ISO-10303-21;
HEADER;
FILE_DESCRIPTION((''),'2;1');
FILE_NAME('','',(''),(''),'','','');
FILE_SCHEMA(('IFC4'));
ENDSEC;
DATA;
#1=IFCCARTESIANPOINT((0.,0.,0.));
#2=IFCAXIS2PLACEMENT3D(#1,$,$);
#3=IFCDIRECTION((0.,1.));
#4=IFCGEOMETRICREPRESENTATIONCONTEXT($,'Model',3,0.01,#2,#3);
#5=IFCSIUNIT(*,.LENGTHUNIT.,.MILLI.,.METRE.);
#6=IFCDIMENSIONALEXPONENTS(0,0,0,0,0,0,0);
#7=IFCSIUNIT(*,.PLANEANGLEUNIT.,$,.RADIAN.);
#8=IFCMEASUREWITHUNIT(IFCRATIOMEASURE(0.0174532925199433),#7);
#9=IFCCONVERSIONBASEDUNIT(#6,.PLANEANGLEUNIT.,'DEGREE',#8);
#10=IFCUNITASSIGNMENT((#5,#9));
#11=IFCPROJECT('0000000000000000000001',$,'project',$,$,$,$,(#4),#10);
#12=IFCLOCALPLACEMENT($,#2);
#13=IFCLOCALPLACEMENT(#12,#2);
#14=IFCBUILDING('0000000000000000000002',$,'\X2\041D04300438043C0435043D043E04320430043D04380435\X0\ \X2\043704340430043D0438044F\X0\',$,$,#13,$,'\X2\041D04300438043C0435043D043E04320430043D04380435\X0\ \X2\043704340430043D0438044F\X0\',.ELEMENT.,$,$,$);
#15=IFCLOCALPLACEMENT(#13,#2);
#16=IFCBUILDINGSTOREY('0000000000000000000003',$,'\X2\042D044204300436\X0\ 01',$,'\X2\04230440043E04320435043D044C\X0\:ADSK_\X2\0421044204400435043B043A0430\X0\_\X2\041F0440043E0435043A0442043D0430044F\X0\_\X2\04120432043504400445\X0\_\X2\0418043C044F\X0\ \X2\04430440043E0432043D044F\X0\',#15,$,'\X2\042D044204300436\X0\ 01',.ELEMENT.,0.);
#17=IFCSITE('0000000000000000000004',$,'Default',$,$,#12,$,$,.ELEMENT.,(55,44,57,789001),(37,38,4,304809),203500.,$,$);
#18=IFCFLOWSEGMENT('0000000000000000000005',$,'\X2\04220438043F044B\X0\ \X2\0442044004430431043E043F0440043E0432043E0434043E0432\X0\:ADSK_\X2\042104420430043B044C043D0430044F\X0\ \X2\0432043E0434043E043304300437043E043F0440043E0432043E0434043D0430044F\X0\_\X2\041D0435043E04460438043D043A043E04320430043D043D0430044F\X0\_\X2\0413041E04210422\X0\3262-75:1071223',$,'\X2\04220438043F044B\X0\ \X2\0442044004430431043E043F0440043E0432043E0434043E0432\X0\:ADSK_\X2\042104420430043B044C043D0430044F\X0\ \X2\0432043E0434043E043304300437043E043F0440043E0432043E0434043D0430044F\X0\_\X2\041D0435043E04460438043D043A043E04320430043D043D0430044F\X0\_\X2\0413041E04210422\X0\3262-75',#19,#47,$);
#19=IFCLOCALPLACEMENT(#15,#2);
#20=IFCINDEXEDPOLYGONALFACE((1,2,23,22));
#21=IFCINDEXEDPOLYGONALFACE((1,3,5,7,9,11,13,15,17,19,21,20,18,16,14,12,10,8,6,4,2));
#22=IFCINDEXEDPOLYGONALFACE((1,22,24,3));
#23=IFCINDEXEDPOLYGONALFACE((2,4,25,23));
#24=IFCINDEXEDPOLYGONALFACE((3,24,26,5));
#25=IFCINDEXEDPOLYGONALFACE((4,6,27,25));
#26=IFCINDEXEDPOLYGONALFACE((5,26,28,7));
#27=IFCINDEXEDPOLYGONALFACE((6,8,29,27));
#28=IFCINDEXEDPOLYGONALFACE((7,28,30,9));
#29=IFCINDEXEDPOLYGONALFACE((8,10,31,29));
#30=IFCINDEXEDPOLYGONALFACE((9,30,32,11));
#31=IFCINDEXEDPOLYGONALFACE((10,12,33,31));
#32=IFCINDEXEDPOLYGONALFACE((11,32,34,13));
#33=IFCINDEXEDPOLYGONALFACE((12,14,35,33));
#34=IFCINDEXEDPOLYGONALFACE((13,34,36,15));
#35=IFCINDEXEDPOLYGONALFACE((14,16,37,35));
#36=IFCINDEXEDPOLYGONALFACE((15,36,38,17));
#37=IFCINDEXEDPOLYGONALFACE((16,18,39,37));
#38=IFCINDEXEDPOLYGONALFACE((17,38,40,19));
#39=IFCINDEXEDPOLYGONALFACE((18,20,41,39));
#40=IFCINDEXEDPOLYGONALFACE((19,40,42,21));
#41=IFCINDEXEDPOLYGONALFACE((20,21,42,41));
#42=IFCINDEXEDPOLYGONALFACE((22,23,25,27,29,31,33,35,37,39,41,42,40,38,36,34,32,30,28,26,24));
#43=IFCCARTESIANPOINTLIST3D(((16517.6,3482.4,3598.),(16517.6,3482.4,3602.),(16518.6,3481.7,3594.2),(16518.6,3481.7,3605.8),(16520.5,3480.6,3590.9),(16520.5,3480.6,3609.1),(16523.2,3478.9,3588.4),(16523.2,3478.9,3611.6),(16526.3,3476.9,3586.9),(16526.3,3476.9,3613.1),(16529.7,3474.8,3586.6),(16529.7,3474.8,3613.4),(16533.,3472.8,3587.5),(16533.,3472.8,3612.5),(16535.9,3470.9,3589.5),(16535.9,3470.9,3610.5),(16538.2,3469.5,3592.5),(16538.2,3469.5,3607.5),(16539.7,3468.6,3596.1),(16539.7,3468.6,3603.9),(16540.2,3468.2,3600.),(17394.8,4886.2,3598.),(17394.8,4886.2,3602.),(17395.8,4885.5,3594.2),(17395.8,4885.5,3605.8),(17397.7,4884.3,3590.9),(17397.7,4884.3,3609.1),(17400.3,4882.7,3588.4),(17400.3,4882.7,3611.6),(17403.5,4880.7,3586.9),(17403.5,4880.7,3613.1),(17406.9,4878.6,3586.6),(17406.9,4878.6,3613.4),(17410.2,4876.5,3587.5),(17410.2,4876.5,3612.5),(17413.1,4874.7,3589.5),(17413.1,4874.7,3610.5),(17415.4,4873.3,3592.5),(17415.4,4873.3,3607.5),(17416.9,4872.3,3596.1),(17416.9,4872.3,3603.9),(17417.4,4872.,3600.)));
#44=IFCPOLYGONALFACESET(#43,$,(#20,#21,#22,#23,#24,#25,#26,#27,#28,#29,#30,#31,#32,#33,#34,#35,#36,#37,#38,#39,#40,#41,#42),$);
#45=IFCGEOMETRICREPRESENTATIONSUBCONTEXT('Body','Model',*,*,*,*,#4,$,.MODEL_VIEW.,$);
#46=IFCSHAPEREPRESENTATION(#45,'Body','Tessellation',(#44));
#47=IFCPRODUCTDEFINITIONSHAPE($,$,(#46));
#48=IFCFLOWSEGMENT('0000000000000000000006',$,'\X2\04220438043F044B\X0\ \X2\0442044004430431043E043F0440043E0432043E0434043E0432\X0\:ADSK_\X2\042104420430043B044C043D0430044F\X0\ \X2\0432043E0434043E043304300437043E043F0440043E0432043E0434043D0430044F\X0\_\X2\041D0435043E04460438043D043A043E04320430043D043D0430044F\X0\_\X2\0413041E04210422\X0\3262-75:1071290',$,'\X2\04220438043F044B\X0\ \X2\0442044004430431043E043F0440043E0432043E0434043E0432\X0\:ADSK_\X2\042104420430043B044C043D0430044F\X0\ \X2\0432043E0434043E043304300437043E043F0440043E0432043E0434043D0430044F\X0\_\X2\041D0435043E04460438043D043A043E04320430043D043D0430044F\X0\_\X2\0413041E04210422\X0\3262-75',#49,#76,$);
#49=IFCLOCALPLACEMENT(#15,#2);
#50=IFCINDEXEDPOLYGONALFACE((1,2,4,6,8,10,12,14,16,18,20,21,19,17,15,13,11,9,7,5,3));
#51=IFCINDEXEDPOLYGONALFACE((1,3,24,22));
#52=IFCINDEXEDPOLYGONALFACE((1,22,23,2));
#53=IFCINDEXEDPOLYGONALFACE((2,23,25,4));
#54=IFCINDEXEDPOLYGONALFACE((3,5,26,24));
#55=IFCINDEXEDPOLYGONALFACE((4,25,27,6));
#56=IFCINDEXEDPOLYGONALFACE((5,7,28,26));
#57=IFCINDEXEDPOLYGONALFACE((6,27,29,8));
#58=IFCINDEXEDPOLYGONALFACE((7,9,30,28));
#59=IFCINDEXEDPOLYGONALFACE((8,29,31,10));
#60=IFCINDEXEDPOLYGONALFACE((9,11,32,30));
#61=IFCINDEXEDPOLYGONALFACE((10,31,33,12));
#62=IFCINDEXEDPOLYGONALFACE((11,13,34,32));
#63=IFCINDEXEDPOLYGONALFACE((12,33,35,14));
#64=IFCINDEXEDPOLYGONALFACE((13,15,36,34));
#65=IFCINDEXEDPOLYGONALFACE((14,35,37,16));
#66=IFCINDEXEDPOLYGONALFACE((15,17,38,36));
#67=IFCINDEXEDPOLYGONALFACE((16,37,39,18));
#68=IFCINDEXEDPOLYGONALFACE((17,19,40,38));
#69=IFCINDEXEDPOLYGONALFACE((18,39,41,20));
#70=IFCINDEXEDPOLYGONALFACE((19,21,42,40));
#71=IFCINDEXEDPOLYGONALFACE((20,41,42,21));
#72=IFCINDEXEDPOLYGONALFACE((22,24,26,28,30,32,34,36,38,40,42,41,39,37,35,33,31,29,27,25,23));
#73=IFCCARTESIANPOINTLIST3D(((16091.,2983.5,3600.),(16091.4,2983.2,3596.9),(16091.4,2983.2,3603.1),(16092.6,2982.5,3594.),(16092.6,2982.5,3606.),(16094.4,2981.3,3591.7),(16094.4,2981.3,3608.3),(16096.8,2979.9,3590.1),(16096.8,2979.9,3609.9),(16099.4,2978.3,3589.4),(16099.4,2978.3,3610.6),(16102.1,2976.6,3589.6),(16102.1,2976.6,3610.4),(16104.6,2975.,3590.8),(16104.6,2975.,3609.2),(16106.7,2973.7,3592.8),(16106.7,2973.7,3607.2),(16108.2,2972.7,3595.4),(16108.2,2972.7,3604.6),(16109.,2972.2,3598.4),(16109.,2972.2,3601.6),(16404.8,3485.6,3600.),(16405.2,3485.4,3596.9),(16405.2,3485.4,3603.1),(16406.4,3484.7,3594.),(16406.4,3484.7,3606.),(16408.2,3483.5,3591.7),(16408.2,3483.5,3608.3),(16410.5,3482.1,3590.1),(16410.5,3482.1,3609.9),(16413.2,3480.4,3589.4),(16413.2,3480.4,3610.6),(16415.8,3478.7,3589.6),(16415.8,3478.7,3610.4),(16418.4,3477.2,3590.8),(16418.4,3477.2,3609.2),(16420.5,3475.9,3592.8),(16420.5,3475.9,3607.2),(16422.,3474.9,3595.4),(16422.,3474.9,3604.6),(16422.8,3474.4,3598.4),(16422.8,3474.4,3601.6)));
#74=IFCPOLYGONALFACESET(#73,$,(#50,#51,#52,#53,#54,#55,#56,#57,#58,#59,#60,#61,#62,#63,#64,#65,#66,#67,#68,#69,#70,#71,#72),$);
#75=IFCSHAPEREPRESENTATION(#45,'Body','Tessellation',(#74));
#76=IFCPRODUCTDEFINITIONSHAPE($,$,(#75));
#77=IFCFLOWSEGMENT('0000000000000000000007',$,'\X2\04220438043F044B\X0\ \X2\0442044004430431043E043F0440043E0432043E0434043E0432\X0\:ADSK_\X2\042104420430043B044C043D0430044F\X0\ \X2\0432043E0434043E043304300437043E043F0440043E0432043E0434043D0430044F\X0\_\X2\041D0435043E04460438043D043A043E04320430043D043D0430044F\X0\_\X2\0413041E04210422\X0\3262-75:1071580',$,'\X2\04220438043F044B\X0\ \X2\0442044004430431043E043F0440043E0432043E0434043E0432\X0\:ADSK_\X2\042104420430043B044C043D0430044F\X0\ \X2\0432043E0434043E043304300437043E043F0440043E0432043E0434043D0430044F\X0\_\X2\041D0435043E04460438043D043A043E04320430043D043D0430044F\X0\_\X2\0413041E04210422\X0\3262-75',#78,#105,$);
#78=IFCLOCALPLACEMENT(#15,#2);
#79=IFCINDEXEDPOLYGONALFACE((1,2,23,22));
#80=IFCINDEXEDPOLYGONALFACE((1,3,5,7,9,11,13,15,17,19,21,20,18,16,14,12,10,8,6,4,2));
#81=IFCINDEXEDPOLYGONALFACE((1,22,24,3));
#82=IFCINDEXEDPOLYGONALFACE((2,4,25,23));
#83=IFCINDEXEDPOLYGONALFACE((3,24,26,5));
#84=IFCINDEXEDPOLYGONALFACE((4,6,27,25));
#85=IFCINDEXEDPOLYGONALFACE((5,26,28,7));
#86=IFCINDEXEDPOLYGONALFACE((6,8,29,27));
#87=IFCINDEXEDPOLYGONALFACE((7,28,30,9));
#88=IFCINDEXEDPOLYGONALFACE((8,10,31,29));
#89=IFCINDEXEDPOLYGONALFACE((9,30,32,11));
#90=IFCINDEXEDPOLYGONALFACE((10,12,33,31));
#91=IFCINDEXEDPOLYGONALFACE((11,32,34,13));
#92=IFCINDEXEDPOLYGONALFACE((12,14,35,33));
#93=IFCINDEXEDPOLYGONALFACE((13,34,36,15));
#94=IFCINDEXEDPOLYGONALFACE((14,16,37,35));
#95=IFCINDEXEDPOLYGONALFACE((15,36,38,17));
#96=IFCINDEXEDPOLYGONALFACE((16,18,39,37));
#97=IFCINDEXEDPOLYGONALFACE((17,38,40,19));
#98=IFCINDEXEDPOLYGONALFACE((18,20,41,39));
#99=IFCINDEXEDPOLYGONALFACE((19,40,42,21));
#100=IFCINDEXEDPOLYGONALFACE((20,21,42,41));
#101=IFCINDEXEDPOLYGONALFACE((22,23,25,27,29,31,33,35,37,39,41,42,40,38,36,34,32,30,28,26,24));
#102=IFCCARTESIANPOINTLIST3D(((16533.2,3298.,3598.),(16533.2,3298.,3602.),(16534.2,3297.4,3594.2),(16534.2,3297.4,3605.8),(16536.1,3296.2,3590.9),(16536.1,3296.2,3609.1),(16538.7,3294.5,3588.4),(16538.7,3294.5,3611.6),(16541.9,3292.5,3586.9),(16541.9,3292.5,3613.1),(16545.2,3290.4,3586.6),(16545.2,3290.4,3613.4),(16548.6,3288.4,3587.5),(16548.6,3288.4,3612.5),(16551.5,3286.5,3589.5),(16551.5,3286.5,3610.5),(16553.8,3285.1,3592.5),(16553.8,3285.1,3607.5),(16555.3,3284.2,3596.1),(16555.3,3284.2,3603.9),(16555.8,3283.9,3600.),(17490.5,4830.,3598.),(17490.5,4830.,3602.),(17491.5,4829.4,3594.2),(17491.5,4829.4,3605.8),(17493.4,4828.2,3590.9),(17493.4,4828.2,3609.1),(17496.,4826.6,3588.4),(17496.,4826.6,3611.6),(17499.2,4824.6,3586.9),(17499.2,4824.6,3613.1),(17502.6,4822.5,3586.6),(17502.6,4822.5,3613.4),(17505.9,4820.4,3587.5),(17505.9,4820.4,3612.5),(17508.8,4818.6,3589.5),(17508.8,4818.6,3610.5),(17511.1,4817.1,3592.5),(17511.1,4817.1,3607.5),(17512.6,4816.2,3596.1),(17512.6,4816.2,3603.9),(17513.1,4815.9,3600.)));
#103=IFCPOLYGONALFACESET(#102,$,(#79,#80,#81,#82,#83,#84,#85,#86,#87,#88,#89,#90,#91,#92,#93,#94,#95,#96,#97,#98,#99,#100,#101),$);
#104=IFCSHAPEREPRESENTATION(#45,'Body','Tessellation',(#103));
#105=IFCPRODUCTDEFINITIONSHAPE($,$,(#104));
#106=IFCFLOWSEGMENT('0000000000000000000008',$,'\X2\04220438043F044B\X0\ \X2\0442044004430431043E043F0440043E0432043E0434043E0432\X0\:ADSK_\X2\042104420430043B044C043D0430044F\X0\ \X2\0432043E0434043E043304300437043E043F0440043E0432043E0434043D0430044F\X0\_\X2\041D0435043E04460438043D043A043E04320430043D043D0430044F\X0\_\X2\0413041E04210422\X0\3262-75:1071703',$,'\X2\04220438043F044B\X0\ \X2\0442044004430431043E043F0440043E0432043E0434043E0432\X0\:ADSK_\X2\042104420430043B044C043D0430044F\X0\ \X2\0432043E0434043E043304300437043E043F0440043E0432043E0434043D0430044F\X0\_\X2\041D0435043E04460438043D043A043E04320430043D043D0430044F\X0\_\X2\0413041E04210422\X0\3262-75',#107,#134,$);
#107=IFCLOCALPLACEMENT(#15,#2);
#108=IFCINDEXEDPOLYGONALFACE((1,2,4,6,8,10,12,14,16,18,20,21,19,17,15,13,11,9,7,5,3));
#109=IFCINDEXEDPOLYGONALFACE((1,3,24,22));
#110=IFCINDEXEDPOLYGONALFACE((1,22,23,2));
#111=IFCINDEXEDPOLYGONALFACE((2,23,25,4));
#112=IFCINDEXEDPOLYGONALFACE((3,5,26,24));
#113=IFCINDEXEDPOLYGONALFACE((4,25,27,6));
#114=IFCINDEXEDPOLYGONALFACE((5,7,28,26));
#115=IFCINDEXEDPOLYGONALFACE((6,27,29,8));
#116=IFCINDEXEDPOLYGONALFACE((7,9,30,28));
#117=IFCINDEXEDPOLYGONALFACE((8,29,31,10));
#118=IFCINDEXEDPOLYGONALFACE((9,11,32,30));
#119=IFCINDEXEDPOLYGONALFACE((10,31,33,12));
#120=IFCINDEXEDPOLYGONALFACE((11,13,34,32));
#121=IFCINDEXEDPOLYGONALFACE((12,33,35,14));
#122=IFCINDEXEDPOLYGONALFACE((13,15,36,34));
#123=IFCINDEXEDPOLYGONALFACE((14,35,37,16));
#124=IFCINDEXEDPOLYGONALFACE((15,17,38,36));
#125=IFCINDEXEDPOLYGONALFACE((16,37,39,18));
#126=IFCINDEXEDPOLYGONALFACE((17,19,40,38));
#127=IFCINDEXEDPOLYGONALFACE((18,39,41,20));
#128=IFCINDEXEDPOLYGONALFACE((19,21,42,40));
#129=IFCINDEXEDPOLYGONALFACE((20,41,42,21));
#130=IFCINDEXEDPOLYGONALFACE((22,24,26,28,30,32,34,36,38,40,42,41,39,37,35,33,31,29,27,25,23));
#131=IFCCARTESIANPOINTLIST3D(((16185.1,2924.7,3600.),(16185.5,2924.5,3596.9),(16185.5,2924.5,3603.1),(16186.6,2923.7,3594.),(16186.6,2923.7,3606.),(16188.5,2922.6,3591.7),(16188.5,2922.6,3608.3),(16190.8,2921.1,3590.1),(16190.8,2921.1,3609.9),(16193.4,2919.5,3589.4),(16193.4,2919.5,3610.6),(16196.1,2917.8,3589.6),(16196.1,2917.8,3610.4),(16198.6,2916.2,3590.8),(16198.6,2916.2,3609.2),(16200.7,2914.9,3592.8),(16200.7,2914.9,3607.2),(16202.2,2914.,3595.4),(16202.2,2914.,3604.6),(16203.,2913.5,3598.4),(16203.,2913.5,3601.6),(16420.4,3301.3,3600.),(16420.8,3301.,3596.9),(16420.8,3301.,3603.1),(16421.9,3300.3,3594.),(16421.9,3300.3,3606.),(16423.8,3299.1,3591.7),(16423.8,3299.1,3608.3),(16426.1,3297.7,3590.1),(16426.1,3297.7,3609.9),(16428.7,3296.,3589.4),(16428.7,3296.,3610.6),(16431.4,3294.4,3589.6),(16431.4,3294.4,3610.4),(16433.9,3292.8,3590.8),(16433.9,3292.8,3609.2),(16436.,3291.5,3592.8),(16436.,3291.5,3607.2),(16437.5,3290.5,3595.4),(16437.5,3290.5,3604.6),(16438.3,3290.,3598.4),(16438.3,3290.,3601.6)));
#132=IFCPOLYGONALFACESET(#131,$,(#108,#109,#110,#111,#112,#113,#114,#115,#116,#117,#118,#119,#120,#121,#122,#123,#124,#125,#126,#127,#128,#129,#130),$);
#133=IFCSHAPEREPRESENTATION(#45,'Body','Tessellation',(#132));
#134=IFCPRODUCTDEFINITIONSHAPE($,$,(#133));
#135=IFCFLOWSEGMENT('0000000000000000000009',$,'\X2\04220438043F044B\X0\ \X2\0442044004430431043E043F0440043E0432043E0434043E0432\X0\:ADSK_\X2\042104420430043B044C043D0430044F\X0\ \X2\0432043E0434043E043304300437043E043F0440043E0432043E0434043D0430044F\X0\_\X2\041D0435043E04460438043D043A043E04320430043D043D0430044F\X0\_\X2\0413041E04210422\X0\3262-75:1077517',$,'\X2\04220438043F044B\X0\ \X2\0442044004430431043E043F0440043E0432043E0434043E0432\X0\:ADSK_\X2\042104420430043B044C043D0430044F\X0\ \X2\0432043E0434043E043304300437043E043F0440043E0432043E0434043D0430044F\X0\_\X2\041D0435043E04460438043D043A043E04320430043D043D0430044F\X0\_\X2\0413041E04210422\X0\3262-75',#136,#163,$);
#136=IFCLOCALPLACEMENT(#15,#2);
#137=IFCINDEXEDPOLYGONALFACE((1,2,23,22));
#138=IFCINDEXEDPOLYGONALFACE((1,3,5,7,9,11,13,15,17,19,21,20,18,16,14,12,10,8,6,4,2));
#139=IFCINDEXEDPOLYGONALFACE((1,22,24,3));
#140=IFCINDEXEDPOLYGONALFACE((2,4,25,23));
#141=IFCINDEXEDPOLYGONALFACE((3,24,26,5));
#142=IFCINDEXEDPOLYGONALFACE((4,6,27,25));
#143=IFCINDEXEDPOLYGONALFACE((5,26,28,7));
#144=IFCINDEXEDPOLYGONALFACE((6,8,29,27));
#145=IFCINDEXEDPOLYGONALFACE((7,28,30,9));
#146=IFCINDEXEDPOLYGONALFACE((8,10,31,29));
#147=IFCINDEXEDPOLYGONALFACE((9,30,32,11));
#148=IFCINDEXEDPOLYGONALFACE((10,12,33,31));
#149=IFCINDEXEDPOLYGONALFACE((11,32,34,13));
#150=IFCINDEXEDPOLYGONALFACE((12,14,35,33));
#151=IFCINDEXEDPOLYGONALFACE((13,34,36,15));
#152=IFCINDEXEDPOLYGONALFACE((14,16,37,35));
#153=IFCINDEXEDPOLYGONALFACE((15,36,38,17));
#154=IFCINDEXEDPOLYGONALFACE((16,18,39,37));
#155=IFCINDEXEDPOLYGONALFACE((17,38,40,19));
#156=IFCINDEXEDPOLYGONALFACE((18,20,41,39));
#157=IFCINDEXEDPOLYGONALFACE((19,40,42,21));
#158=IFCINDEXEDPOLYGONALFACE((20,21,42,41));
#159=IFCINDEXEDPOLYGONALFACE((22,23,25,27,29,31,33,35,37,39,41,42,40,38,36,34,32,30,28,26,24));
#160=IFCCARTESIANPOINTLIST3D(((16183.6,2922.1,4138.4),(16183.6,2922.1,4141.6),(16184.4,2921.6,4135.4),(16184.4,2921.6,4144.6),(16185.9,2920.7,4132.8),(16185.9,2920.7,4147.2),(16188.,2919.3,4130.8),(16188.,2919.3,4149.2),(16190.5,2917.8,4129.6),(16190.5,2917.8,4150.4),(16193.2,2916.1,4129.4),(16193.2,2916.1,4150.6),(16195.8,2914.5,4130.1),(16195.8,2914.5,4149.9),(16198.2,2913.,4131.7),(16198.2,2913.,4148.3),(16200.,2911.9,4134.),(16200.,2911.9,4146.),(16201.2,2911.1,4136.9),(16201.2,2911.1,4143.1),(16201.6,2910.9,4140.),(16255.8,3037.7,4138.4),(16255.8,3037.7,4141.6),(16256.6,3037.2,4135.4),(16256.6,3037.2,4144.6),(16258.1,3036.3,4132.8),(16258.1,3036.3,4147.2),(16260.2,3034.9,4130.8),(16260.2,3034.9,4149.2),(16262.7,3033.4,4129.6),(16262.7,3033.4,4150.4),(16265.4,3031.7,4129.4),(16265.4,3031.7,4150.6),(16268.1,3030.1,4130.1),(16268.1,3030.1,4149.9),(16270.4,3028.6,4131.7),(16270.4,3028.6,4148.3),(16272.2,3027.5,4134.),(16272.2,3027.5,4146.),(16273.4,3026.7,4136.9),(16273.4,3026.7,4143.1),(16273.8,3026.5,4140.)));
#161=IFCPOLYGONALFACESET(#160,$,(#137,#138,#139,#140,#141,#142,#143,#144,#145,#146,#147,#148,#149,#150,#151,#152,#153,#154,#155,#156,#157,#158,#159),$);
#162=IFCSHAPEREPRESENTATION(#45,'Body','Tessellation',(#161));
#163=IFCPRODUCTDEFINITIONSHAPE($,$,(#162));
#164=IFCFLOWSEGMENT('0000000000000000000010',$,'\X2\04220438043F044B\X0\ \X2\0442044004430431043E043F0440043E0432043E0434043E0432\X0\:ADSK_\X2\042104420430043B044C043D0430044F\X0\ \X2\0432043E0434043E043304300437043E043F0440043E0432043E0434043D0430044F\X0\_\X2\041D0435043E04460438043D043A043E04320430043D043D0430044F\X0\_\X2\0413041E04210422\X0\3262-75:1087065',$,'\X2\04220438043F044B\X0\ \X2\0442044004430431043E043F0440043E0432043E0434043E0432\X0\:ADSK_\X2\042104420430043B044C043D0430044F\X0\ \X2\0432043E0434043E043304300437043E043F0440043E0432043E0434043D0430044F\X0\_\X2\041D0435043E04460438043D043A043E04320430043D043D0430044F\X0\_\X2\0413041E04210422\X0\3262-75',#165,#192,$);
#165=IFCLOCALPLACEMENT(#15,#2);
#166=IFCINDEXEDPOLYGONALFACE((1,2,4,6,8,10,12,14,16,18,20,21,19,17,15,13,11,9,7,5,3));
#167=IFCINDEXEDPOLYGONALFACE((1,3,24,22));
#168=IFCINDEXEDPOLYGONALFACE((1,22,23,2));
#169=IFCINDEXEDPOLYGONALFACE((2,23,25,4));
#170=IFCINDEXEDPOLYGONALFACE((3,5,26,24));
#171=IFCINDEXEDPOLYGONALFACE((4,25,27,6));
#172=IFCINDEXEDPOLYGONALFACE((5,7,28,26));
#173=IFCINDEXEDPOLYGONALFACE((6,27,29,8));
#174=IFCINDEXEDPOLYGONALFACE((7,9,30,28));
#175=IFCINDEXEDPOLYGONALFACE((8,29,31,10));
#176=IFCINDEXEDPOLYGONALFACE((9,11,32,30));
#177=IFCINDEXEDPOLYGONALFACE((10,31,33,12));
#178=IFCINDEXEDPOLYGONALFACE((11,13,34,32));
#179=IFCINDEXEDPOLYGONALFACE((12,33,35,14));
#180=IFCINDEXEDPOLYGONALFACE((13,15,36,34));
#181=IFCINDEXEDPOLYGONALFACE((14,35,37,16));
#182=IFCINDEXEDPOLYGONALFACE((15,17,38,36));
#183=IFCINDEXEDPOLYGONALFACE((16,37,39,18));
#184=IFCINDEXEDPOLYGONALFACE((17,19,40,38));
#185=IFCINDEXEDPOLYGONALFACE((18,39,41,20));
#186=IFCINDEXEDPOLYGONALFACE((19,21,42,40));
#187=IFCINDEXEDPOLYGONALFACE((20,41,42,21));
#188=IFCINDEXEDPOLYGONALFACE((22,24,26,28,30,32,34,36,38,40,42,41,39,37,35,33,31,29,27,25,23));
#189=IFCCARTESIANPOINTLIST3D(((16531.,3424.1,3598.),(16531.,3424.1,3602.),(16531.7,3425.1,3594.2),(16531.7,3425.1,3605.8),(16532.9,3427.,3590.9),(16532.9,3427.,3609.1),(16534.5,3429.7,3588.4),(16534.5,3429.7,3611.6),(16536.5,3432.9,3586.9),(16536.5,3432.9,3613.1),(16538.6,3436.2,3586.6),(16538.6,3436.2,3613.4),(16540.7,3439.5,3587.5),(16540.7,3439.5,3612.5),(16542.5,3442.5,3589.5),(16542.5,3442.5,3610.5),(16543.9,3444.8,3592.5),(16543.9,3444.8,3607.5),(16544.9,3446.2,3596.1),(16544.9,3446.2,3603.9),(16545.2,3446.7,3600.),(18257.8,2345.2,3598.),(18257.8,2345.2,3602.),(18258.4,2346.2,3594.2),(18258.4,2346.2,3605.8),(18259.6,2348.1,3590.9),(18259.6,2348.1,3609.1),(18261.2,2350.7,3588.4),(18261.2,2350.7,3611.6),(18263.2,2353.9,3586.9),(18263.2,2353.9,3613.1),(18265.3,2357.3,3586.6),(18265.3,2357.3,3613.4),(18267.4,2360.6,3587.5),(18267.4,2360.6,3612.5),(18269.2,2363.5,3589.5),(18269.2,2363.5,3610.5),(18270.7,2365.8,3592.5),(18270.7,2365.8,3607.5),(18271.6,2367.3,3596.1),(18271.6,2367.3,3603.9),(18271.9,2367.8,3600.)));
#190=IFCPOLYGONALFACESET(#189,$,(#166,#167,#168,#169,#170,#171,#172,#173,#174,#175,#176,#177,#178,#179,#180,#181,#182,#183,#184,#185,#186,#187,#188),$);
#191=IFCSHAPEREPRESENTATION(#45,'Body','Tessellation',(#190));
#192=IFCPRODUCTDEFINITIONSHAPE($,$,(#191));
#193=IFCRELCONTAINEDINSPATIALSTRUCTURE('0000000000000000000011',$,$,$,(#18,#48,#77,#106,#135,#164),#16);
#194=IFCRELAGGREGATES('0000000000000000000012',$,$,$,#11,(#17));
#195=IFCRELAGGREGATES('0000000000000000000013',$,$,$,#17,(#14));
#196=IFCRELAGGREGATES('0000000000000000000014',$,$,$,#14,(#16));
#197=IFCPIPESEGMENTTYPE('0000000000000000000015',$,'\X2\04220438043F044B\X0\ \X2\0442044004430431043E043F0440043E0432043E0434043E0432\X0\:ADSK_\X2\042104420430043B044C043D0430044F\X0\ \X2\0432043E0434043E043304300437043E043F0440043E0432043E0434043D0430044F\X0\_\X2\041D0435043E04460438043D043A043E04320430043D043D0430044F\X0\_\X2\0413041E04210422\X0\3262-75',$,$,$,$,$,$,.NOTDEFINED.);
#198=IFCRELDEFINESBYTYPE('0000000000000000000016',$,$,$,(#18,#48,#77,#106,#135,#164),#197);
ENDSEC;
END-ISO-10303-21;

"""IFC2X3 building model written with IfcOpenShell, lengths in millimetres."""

from ifc_helpers import new_model, entity, si_unit, converted_unit, direction, frame, origin, origin_2d_with_axis, place, context, subcontext, project, spatial, circle, extrude, type_object, element, save


model = new_model("IFC2X3")

# Units and contexts
model_context = context("Model", 3, precision=0.01, world=origin(), true_north=direction((0.0, 1.0)))
body_context = subcontext(model_context, "Body", "Model", "MODEL_VIEW")
ifc_project = project(units=[si_unit("LENGTHUNIT", "METRE", prefix="MILLI"), converted_unit("PLANEANGLEUNIT", "DEGREE", entity("IfcRatioMeasure", 0.0174532925199433), si_unit("PLANEANGLEUNIT", "RADIAN"), dimensions=[0, 0, 0, 0, 0, 0, 0])], contexts=[model_context])

# Site, building, storey
site_placement = place(None, origin())
site = spatial("IfcSite", under=ifc_project, at=site_placement, Name="Default", CompositionType="ELEMENT", RefLatitude=(55, 44, 57, 789001), RefLongitude=(37, 38, 4, 304809), RefElevation=203500.0)
building_placement = place(site_placement, origin())
building = spatial("IfcBuilding", under=site, at=building_placement, Name="Наименование здания", LongName="Наименование здания", CompositionType="ELEMENT")
storey_placement = place(building_placement, origin())
storey = spatial("IfcBuildingStorey", under=building, at=storey_placement, Name="Этаж 01", ObjectType="Уровень:ADSK_Стрелка_Проектная_Вверх_Имя уровня", LongName="Этаж 01", CompositionType="ELEMENT", Elevation=0.0)

# Flow segments
pipe_segment_type = type_object("IfcPipeSegmentType", Name="Типы трубопроводов:ADSK_Стальная водогазопроводная_Неоцинкованная_ГОСТ3262-75", PredefinedType="NOTDEFINED")
flow_segment_1_placement = place(storey_placement, frame((16515.9, 3466.7, 3585.0)))
element("IfcFlowSegment", 1, at=flow_segment_1_placement, inside=storey, type_object=pipe_segment_type, Name="Типы трубопроводов:ADSK_Стальная водогазопроводная_Неоцинкованная_ГОСТ3262-75:1071223", ObjectType="Типы трубопроводов:ADSK_Стальная водогазопроводная_Неоцинкованная_ГОСТ3262-75", context=body_context, shape_type="SweptSolid", body=[
    extrude(circle(Radius=13.4, at=origin_2d_with_axis()), frame((13.0, 8.7, 15.0), z_axis=(0.529912, 0.848053, 0.0), x_axis=(0.848053, -0.529912, 0.0)), (0.0, 0.0, 1.0), 1655.3),
])
flow_segment_2_placement = place(storey_placement, frame((16089.4, 2970.6, 3587.8)))
element("IfcFlowSegment", 2, at=flow_segment_2_placement, inside=storey, type_object=pipe_segment_type, Name="Типы трубопроводов:ADSK_Стальная водогазопроводная_Неоцинкованная_ГОСТ3262-75:1071290", ObjectType="Типы трубопроводов:ADSK_Стальная водогазопроводная_Неоцинкованная_ГОСТ3262-75", context=body_context, shape_type="SweptSolid", body=[
    extrude(circle(Radius=10.7, at=origin_2d_with_axis()), frame((10.6, 7.2, 12.2), z_axis=(0.529911, 0.848053, 0.0), x_axis=(-0.848053, 0.529911, 0.0)), (0.0, 0.0, 1.0), 592.1),
])
flow_segment_3_placement = place(storey_placement, frame((16531.4, 3282.3, 3585.0)))
element("IfcFlowSegment", 3, at=flow_segment_3_placement, inside=storey, type_object=pipe_segment_type, Name="Типы трубопроводов:ADSK_Стальная водогазопроводная_Неоцинкованная_ГОСТ3262-75:1071580", ObjectType="Типы трубопроводов:ADSK_Стальная водогазопроводная_Неоцинкованная_ГОСТ3262-75", context=body_context, shape_type="SweptSolid", body=[
    extrude(circle(Radius=13.4, at=origin_2d_with_axis()), frame((13.0, 8.7, 15.0), z_axis=(0.529912, 0.848053, 0.0), x_axis=(0.848053, -0.529912, 0.0)), (0.0, 0.0, 1.0), 1806.5),
])
flow_segment_4_placement = place(storey_placement, frame((16183.5, 2911.8, 3587.8)))
element("IfcFlowSegment", 4, at=flow_segment_4_placement, inside=storey, type_object=pipe_segment_type, Name="Типы трубопроводов:ADSK_Стальная водогазопроводная_Неоцинкованная_ГОСТ3262-75:1071703", ObjectType="Типы трубопроводов:ADSK_Стальная водогазопроводная_Неоцинкованная_ГОСТ3262-75", context=body_context, shape_type="SweptSolid", body=[
    extrude(circle(Radius=10.7, at=origin_2d_with_axis()), frame((10.6, 7.2, 12.2), z_axis=(0.529911, 0.848053, 0.0), x_axis=(-0.848053, 0.529911, 0.0)), (0.0, 0.0, 1.0), 444.0),
])
flow_segment_5_placement = place(storey_placement, frame((16181.9, 2909.3, 4127.8)))
element("IfcFlowSegment", 5, at=flow_segment_5_placement, inside=storey, type_object=pipe_segment_type, Name="Типы трубопроводов:ADSK_Стальная водогазопроводная_Неоцинкованная_ГОСТ3262-75:1077517", ObjectType="Типы трубопроводов:ADSK_Стальная водогазопроводная_Неоцинкованная_ГОСТ3262-75", context=body_context, shape_type="SweptSolid", body=[
    extrude(circle(Radius=10.7, at=origin_2d_with_axis()), frame((10.6, 7.2, 12.2), z_axis=(0.529909, 0.848055, 0.0), x_axis=(0.848055, -0.529909, 0.0)), (0.0, 0.0, 1.0), 136.3),
])
flow_segment_6_placement = place(storey_placement, frame((16529.4, 2343.5, 3585.0)))
element("IfcFlowSegment", 6, at=flow_segment_6_placement, inside=storey, type_object=pipe_segment_type, Name="Типы трубопроводов:ADSK_Стальная водогазопроводная_Неоцинкованная_ГОСТ3262-75:1087065", ObjectType="Типы трубопроводов:ADSK_Стальная водогазопроводная_Неоцинкованная_ГОСТ3262-75", context=body_context, shape_type="SweptSolid", body=[
    extrude(circle(Radius=13.4, at=origin_2d_with_axis()), frame((1735.4, 13.0, 15.0), z_axis=(-0.848053, 0.529912, 0.0), x_axis=(0.529912, 0.848053, 0.0)), (0.0, 0.0, 1.0), 2036.1),
])

save(model, "model.ifc")
